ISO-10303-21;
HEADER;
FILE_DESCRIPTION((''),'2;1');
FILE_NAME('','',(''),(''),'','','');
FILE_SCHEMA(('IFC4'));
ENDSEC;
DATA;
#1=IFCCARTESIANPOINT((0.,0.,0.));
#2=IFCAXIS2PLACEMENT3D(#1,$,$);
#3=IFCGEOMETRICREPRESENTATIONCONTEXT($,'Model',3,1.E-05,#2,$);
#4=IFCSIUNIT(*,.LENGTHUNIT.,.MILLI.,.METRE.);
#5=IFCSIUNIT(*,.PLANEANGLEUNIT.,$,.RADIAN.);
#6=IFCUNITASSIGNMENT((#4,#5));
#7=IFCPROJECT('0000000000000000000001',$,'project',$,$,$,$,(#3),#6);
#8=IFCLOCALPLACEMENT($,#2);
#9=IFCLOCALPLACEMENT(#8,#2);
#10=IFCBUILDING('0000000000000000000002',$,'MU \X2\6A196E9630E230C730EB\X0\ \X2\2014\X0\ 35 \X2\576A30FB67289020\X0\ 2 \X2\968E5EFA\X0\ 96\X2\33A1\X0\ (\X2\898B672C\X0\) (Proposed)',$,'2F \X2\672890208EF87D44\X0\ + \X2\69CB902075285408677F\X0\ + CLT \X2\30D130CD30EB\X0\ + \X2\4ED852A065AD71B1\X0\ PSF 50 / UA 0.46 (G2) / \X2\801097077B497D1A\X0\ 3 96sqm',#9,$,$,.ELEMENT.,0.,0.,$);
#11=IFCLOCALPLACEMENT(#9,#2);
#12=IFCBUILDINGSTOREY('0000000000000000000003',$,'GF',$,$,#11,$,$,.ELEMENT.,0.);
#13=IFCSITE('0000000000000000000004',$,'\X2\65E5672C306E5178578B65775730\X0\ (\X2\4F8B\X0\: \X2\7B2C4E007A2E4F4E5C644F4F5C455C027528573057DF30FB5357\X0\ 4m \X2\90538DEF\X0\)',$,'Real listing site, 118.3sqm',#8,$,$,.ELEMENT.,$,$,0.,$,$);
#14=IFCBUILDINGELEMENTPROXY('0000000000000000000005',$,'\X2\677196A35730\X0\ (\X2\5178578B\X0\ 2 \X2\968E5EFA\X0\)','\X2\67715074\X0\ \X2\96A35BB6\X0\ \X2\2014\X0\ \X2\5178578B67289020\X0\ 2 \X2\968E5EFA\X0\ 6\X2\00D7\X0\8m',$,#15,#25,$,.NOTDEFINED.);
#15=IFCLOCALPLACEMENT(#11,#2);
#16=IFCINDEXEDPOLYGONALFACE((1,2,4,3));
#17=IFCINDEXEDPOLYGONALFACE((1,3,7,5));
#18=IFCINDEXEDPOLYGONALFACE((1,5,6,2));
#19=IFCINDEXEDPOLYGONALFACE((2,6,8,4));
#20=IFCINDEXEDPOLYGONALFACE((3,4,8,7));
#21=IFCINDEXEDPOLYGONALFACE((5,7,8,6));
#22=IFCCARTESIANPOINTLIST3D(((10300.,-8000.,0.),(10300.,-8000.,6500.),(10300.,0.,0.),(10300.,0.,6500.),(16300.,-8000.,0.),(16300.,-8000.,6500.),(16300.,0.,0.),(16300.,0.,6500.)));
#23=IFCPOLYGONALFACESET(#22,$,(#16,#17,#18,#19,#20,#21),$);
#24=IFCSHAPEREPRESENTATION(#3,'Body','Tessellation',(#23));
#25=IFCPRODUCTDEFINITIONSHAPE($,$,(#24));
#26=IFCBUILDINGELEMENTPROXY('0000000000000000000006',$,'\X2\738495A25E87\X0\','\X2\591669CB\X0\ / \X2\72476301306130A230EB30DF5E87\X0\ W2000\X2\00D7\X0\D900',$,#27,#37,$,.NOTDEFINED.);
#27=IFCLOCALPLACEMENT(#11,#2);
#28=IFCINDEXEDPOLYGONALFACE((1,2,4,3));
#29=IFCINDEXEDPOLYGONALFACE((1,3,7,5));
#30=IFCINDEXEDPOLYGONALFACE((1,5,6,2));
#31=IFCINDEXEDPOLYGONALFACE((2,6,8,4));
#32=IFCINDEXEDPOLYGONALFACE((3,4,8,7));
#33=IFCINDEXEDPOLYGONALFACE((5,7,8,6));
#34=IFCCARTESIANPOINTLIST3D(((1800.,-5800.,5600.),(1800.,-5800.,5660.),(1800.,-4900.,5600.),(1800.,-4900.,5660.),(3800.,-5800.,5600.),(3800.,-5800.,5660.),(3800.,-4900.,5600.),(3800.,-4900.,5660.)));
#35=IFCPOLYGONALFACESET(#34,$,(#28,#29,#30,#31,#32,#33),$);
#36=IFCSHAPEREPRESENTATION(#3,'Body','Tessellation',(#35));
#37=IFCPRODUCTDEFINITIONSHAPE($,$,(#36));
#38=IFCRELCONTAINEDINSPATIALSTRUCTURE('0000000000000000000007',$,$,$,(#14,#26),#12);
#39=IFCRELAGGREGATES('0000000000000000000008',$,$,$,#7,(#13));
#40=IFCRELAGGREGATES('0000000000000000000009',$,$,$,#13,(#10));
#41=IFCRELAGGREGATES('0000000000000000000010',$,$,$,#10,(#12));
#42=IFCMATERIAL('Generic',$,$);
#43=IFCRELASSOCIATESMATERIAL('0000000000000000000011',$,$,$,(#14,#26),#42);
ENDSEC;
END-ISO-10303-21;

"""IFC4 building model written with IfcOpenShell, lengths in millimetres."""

from ifc_helpers import new_model, si_unit, frame, frame_2d, origin, place, context, project, spatial, rectangle, extrude, material, element, save


model = new_model("IFC4")

# Units and contexts
model_context = context("Model", 3, precision=1e-05, world=origin())
ifc_project = project(units=[si_unit("LENGTHUNIT", "METRE", prefix="MILLI"), si_unit("PLANEANGLEUNIT", "RADIAN")], contexts=[model_context])

# Site, building, storey
site_placement = place(None, origin())
site = spatial("IfcSite", under=ifc_project, at=site_placement, Name="日本の典型敷地 (例: 第一種低層住居専用地域・南 4m 道路)", ObjectType="Real listing site, 118.3sqm", CompositionType="ELEMENT", RefElevation=0.0)
building_placement = place(site_placement, origin())
building = spatial("IfcBuilding", under=site, at=building_placement, Name="MU 標準モデル — 35 坪・木造 2 階建 96㎡ (見本) (Proposed)", ObjectType="2F 木造軸組 + 構造用合板 + CLT パネル + 付加断熱 PSF 50 / UA 0.46 (G2) / 耐震等級 3 96sqm", CompositionType="ELEMENT", ElevationOfRefHeight=0.0, ElevationOfTerrain=0.0)
storey_placement = place(building_placement, origin())
storey = spatial("IfcBuildingStorey", under=building, at=storey_placement, Name="GF", CompositionType="ELEMENT", Elevation=0.0)

# Shared definitions
ifc_material_1 = material(Name="Generic")

# Building element proxies
proxy_1_placement = place(storey_placement, frame((5150.0, -4000.0, 0.0)))
element("IfcBuildingElementProxy", 1, at=proxy_1_placement, inside=storey, material=ifc_material_1, Name="東隣地 (典型 2 階建)", Description="東側 隣家 — 典型木造 2 階建 6×8m", PredefinedType="NOTDEFINED", context=model_context, shape_type="SweptSolid", body=[
    extrude(rectangle(XDim=6000.0, YDim=8000.0, at=frame_2d((3000.0, 4000.0))), frame((5150.0, -4000.0, 0.0)), (0.0, 0.0, 1.0), 6500.0),
])
proxy_2_placement = place(storey_placement, frame((900.0, -2900.0, 2800.0)))
element("IfcBuildingElementProxy", 2, at=proxy_2_placement, inside=storey, material=ifc_material_1, Name="玄関庇", Description="外構 / 片持ちアルミ庇 W2000×D900", PredefinedType="NOTDEFINED", context=model_context, shape_type="SweptSolid", body=[
    extrude(rectangle(XDim=2000.0, YDim=900.0, at=frame_2d((1000.0, 450.0))), frame((900.0, -2900.0, 2800.0)), (0.0, 0.0, 1.0), 60.0),
])

save(model, "model.ifc")
